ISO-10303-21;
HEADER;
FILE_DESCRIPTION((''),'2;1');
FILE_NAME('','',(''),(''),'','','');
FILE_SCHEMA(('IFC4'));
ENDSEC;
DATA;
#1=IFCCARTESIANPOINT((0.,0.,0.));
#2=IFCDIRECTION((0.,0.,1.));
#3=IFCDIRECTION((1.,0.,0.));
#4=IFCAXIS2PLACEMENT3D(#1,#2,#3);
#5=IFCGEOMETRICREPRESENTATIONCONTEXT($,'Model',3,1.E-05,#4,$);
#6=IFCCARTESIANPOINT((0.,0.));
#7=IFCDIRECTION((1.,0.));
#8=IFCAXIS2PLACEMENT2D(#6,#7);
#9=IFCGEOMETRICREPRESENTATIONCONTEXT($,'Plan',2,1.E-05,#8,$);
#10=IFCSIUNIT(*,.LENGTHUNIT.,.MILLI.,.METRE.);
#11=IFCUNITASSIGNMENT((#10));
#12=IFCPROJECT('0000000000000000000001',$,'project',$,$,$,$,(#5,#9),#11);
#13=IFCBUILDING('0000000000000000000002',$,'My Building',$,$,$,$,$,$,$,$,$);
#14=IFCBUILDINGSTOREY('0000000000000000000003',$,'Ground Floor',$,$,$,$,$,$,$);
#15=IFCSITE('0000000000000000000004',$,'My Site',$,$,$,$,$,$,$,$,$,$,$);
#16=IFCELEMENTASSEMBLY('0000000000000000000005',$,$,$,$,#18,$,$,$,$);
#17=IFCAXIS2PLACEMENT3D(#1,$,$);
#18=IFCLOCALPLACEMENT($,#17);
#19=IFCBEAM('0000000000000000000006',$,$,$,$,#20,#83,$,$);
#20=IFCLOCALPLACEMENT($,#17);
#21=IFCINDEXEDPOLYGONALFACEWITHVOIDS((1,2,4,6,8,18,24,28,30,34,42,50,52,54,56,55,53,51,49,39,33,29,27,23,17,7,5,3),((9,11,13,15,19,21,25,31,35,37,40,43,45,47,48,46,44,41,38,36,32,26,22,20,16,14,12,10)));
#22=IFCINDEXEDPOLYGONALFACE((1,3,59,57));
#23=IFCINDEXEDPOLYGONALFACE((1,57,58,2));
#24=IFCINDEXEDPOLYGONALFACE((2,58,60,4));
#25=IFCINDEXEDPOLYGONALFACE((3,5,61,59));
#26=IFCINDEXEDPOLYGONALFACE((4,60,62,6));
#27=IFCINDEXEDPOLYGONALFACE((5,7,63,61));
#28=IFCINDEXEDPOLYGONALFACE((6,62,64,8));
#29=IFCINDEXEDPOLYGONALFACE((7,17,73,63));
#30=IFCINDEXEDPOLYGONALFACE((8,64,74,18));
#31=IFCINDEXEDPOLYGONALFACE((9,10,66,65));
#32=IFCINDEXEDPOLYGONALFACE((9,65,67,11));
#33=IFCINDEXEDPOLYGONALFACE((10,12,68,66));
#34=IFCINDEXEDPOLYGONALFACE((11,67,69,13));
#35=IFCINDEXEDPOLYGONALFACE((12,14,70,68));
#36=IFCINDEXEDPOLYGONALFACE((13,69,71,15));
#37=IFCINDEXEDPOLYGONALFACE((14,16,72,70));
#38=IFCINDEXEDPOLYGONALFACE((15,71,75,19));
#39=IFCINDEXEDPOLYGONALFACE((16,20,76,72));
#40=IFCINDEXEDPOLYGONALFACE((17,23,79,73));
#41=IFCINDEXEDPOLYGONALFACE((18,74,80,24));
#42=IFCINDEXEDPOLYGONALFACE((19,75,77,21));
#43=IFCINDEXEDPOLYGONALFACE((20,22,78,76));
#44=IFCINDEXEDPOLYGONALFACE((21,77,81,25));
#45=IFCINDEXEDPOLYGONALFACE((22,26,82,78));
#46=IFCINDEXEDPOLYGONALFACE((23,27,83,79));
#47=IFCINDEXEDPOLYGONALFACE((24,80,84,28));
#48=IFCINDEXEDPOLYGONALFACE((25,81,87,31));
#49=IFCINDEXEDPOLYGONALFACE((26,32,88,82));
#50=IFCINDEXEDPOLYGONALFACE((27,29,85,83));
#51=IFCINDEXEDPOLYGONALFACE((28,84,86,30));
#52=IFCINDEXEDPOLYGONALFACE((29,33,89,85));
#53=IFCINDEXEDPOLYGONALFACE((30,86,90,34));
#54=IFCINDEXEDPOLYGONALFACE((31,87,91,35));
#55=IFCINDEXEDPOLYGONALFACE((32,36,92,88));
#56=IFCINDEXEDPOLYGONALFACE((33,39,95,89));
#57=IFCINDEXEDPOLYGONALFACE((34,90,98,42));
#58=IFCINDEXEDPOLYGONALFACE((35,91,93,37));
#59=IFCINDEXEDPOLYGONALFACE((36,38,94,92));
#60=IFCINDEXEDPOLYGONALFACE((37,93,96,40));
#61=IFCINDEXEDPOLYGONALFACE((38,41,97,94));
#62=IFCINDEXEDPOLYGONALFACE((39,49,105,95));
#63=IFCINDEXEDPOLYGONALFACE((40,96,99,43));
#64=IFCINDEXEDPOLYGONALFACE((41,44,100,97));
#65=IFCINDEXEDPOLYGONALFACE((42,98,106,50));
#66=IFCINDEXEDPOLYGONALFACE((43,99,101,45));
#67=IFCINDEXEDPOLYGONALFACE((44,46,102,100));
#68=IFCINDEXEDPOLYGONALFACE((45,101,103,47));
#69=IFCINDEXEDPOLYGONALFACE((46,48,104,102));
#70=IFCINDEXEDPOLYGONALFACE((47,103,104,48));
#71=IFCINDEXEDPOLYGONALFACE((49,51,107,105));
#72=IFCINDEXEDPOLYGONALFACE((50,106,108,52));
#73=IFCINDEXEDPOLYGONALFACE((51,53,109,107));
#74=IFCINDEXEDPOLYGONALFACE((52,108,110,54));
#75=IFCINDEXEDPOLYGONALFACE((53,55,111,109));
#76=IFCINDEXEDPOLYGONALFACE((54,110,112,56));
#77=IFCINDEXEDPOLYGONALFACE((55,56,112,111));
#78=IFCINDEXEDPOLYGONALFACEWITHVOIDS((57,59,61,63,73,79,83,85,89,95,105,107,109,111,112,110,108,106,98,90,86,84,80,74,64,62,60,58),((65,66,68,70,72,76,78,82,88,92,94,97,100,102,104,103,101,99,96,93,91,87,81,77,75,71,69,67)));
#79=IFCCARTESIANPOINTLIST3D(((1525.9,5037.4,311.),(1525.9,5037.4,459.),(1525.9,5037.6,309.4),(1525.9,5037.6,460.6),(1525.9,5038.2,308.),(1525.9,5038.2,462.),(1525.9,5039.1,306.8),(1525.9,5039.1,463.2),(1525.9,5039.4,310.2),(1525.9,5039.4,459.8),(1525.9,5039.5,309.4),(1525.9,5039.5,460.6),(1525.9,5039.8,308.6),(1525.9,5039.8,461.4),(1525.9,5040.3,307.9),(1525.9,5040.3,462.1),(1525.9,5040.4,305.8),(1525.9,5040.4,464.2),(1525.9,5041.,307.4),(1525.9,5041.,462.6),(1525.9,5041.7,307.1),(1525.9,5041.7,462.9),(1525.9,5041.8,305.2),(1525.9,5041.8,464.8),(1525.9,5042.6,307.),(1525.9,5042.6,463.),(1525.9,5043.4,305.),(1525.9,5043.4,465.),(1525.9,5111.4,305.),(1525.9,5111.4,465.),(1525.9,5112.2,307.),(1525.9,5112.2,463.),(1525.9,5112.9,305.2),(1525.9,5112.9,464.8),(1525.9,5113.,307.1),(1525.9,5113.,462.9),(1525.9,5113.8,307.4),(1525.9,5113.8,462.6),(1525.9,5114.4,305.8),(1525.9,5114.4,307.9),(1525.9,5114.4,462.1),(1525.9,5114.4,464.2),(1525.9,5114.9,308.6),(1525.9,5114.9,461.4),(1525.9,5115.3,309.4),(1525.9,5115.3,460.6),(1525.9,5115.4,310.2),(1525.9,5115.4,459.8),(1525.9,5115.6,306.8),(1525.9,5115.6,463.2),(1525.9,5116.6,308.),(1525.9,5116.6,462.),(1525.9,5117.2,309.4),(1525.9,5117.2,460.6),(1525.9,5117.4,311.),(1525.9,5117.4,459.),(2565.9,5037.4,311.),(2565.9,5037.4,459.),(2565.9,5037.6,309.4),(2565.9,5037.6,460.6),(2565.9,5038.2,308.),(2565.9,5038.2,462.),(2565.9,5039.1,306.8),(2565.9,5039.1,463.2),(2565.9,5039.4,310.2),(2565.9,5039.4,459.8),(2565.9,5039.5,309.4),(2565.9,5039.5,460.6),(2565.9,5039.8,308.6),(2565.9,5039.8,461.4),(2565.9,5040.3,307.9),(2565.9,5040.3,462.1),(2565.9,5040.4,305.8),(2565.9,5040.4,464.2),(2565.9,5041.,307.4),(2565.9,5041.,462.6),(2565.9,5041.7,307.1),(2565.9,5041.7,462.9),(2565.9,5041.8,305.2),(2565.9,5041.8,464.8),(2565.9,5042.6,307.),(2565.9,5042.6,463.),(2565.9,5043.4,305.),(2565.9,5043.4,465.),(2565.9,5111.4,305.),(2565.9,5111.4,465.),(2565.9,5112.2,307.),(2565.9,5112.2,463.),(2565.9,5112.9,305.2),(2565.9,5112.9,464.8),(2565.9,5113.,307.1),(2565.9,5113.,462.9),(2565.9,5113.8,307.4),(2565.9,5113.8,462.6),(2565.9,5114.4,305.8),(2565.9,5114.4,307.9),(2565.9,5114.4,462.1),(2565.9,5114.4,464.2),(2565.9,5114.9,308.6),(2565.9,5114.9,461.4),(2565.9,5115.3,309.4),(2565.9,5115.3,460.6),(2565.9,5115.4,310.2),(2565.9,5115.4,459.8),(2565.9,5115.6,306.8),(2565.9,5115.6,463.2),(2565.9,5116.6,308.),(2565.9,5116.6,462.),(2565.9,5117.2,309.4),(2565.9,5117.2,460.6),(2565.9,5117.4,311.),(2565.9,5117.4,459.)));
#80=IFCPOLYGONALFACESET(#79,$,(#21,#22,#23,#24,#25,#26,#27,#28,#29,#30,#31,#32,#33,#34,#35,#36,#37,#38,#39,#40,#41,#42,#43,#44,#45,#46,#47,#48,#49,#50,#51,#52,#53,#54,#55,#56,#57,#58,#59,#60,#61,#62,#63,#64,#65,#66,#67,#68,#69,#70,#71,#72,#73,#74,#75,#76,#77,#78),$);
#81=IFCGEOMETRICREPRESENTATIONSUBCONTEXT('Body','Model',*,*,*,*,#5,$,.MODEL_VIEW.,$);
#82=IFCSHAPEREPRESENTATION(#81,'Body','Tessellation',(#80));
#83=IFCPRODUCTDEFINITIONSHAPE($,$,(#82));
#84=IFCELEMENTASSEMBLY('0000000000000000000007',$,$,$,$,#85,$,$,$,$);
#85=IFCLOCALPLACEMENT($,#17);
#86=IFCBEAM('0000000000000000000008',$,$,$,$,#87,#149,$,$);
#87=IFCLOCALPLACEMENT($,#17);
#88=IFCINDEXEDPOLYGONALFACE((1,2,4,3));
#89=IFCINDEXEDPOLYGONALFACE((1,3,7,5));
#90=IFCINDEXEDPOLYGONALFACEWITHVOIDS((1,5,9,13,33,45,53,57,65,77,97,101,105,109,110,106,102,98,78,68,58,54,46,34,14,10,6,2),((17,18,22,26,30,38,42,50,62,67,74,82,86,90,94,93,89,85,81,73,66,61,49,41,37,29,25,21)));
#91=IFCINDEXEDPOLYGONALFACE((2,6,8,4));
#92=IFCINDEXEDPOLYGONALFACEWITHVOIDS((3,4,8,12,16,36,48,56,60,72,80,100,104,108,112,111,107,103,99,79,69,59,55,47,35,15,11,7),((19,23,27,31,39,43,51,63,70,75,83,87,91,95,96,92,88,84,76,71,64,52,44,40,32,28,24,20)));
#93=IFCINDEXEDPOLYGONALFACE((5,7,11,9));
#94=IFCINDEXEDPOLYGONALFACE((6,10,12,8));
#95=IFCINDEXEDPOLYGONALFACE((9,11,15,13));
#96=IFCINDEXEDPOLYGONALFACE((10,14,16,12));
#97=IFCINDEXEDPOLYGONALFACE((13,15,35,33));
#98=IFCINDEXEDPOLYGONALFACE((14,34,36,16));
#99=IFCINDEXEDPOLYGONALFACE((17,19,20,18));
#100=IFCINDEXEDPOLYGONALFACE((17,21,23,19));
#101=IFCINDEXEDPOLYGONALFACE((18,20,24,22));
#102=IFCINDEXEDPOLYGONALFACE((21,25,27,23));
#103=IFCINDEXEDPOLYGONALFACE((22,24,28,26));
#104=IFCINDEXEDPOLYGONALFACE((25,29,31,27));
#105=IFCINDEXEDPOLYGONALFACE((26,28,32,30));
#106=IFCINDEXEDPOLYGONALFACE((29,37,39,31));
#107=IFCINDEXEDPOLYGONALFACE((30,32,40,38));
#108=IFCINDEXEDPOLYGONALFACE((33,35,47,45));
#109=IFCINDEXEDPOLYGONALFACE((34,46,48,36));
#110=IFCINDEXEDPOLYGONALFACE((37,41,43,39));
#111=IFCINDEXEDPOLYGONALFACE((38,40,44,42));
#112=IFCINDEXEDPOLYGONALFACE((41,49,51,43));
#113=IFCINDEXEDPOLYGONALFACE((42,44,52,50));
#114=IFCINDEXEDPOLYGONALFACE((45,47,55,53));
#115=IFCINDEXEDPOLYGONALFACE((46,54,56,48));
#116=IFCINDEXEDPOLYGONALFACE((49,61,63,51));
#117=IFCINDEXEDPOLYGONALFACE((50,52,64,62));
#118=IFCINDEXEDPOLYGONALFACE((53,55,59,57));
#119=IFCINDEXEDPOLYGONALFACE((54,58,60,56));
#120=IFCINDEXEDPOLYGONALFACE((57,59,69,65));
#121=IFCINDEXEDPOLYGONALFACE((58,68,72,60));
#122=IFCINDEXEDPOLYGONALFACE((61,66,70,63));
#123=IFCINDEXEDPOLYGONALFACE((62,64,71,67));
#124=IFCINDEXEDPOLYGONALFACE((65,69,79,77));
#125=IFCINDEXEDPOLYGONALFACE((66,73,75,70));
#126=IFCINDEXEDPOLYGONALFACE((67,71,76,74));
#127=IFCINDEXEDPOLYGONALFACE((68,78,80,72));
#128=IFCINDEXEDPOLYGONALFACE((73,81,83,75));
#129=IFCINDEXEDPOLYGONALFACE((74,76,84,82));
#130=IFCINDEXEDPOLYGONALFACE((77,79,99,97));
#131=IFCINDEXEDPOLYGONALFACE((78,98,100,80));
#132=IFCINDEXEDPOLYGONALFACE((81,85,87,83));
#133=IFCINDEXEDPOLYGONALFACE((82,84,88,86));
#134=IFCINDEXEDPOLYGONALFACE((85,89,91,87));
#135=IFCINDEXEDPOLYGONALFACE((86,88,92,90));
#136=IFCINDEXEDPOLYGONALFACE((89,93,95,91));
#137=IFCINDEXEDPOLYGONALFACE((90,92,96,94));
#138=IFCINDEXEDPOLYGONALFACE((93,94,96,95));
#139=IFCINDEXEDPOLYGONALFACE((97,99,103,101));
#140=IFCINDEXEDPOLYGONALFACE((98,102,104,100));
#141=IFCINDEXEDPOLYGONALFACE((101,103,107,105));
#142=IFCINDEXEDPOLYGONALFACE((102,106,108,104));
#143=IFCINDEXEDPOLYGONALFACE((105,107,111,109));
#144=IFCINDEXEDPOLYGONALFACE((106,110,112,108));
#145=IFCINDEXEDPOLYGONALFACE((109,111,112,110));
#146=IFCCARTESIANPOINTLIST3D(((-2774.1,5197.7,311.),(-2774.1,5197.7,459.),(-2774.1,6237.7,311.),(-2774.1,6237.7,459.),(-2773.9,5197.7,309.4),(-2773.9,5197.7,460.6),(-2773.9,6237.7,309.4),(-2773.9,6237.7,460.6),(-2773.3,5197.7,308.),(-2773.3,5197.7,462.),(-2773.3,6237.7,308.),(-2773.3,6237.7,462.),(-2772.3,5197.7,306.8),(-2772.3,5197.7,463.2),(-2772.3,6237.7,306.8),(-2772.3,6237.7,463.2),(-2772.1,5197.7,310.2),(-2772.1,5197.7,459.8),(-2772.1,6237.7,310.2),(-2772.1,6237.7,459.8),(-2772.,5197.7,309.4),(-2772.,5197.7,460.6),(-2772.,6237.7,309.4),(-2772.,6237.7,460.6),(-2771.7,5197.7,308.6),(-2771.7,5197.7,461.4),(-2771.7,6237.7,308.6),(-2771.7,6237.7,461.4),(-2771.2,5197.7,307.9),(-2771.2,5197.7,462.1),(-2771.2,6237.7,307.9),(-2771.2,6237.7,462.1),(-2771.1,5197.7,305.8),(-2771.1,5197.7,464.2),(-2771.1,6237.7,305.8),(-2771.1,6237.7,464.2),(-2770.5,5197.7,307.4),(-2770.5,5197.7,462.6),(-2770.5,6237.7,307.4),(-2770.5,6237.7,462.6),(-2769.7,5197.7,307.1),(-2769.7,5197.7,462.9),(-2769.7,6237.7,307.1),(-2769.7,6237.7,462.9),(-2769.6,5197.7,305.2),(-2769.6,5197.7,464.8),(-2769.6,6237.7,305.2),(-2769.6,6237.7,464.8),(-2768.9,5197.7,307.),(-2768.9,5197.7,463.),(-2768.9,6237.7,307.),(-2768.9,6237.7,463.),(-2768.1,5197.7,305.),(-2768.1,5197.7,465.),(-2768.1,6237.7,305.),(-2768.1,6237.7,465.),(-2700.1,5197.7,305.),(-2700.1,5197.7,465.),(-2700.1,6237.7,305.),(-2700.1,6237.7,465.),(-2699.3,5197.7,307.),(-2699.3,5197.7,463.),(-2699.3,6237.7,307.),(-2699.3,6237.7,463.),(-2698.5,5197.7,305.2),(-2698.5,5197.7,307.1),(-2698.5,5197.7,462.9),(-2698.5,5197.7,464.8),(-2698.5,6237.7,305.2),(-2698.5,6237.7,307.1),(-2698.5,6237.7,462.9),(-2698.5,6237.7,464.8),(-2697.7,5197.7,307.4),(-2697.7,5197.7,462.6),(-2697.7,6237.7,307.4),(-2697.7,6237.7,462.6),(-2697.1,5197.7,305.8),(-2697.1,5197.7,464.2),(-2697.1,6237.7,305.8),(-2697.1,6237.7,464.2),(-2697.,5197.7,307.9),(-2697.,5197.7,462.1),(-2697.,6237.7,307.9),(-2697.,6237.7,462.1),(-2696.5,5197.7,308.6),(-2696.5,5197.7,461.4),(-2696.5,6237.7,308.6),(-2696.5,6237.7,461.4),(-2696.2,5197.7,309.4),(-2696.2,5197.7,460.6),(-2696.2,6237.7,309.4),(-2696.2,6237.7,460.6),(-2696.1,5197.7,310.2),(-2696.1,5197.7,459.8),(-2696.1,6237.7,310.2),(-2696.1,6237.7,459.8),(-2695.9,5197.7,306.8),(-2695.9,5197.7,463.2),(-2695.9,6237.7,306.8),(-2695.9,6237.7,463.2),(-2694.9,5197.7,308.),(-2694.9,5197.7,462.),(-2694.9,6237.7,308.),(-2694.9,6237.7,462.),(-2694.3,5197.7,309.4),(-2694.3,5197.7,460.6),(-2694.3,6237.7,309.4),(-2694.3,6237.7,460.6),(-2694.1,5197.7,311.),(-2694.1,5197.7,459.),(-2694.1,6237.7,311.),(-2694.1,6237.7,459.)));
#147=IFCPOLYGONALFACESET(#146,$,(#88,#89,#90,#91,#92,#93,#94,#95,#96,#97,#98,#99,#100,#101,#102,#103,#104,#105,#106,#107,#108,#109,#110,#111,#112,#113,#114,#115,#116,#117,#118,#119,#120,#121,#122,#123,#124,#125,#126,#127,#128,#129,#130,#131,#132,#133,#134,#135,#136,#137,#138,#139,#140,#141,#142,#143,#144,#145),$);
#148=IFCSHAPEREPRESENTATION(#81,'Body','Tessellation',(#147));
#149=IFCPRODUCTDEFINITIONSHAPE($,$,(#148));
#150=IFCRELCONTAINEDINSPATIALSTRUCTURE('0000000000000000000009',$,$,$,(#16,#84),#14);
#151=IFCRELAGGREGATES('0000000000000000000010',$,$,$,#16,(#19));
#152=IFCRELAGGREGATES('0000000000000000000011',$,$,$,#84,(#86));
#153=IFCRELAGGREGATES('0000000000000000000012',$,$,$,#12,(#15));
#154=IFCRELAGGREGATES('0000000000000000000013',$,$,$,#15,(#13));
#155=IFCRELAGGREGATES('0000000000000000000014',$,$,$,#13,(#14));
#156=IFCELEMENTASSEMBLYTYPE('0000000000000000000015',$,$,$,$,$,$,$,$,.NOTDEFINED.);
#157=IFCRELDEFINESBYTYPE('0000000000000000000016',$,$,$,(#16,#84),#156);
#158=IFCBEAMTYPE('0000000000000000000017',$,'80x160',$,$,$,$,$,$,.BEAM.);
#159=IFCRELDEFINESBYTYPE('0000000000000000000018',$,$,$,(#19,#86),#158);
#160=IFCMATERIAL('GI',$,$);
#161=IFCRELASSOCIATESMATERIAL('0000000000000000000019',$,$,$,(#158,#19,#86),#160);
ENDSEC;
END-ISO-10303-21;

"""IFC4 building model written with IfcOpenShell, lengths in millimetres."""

from ifc_helpers import new_model, si_unit, frame, origin_with_axes, origin_2d_with_axis, place, context, subcontext, project, spatial, hollow_rectangle, extrude, material, material_profile, profile_set, profile_usage, type_object, element, aggregate, save


model = new_model("IFC4")

# Units and contexts
model_context = context("Model", 3, precision=1e-05, world=origin_with_axes())
plan_context = context("Plan", 2, precision=1e-05, world=origin_2d_with_axis())
body_context = subcontext(model_context, "Body", "Model", "MODEL_VIEW")
ifc_project = project(units=[si_unit("LENGTHUNIT", "METRE", prefix="MILLI")], contexts=[model_context, plan_context])

# Site, building, storey
site = spatial("IfcSite", under=ifc_project, Name="My Site")
building = spatial("IfcBuilding", under=site, Name="My Building")
storey = spatial("IfcBuildingStorey", under=building, Name="Ground Floor")

# Shared definitions
ifc_material = material(Name="GI")

# Element assemblies, beams
element_assembly_type_1 = type_object("IfcElementAssemblyType", PredefinedType="NOTDEFINED")
ifc_material_profile_1 = material_profile(ifc_material, hollow_rectangle(XDim=80.0, YDim=160.0, WallThickness=2.0, InnerFilletRadius=3.2, OuterFilletRadius=6.0))
ifc_profile_set_1 = profile_set([ifc_material_profile_1], Name="80x160 GI Rectangular Hollow")
beam_type = type_object("IfcBeamType", Name="80x160", PredefinedType="BEAM", material=ifc_profile_set_1)
assembly_1_placement = place(None, frame((1445.9, 5077.4, 385.0), z_axis=(1.0, 0.0, 0.0), x_axis=(0.0, 1.0, 0.0)))
assembly_1 = element("IfcElementAssembly", 1, at=assembly_1_placement, inside=storey, type_object=element_assembly_type_1)
ifc_profile_usage_1 = profile_usage(ifc_profile_set_1)
beam_1_placement = place(assembly_1_placement, frame((0.0, 0.0, 80.0), z_axis=(0.0, 0.0, 1.0), x_axis=(1.0, 0.0, 0.0)))
beam_1 = element("IfcBeam", 2, at=beam_1_placement, type_object=beam_type, material=ifc_profile_usage_1, context=body_context, shape_type="SweptSolid", body=[
    extrude(hollow_rectangle(XDim=80.0, YDim=160.0, WallThickness=2.0, InnerFilletRadius=3.2, OuterFilletRadius=6.0), origin_with_axes(), (0.0, 0.0, 1.0), 1040.0),
])
aggregate(assembly_1, [beam_1])
assembly_2_placement = place(None, frame((-2734.1, 5117.7, 385.0), z_axis=(0.0, 1.0, 0.0), x_axis=(1.0, 0.0, 0.0)))
assembly_2 = element("IfcElementAssembly", 3, at=assembly_2_placement, inside=storey, type_object=element_assembly_type_1)
ifc_profile_usage_2 = profile_usage(ifc_profile_set_1)
beam_2_placement = place(assembly_2_placement, frame((0.0, 0.0, 80.0), z_axis=(0.0, 0.0, 1.0), x_axis=(1.0, 0.0, 0.0)))
beam_2 = element("IfcBeam", 4, at=beam_2_placement, type_object=beam_type, material=ifc_profile_usage_2, context=body_context, shape_type="SweptSolid", body=[
    extrude(hollow_rectangle(XDim=80.0, YDim=160.0, WallThickness=2.0, InnerFilletRadius=3.2, OuterFilletRadius=6.0), origin_with_axes(), (0.0, 0.0, 1.0), 1040.0),
])
aggregate(assembly_2, [beam_2])

save(model, "model.ifc")
